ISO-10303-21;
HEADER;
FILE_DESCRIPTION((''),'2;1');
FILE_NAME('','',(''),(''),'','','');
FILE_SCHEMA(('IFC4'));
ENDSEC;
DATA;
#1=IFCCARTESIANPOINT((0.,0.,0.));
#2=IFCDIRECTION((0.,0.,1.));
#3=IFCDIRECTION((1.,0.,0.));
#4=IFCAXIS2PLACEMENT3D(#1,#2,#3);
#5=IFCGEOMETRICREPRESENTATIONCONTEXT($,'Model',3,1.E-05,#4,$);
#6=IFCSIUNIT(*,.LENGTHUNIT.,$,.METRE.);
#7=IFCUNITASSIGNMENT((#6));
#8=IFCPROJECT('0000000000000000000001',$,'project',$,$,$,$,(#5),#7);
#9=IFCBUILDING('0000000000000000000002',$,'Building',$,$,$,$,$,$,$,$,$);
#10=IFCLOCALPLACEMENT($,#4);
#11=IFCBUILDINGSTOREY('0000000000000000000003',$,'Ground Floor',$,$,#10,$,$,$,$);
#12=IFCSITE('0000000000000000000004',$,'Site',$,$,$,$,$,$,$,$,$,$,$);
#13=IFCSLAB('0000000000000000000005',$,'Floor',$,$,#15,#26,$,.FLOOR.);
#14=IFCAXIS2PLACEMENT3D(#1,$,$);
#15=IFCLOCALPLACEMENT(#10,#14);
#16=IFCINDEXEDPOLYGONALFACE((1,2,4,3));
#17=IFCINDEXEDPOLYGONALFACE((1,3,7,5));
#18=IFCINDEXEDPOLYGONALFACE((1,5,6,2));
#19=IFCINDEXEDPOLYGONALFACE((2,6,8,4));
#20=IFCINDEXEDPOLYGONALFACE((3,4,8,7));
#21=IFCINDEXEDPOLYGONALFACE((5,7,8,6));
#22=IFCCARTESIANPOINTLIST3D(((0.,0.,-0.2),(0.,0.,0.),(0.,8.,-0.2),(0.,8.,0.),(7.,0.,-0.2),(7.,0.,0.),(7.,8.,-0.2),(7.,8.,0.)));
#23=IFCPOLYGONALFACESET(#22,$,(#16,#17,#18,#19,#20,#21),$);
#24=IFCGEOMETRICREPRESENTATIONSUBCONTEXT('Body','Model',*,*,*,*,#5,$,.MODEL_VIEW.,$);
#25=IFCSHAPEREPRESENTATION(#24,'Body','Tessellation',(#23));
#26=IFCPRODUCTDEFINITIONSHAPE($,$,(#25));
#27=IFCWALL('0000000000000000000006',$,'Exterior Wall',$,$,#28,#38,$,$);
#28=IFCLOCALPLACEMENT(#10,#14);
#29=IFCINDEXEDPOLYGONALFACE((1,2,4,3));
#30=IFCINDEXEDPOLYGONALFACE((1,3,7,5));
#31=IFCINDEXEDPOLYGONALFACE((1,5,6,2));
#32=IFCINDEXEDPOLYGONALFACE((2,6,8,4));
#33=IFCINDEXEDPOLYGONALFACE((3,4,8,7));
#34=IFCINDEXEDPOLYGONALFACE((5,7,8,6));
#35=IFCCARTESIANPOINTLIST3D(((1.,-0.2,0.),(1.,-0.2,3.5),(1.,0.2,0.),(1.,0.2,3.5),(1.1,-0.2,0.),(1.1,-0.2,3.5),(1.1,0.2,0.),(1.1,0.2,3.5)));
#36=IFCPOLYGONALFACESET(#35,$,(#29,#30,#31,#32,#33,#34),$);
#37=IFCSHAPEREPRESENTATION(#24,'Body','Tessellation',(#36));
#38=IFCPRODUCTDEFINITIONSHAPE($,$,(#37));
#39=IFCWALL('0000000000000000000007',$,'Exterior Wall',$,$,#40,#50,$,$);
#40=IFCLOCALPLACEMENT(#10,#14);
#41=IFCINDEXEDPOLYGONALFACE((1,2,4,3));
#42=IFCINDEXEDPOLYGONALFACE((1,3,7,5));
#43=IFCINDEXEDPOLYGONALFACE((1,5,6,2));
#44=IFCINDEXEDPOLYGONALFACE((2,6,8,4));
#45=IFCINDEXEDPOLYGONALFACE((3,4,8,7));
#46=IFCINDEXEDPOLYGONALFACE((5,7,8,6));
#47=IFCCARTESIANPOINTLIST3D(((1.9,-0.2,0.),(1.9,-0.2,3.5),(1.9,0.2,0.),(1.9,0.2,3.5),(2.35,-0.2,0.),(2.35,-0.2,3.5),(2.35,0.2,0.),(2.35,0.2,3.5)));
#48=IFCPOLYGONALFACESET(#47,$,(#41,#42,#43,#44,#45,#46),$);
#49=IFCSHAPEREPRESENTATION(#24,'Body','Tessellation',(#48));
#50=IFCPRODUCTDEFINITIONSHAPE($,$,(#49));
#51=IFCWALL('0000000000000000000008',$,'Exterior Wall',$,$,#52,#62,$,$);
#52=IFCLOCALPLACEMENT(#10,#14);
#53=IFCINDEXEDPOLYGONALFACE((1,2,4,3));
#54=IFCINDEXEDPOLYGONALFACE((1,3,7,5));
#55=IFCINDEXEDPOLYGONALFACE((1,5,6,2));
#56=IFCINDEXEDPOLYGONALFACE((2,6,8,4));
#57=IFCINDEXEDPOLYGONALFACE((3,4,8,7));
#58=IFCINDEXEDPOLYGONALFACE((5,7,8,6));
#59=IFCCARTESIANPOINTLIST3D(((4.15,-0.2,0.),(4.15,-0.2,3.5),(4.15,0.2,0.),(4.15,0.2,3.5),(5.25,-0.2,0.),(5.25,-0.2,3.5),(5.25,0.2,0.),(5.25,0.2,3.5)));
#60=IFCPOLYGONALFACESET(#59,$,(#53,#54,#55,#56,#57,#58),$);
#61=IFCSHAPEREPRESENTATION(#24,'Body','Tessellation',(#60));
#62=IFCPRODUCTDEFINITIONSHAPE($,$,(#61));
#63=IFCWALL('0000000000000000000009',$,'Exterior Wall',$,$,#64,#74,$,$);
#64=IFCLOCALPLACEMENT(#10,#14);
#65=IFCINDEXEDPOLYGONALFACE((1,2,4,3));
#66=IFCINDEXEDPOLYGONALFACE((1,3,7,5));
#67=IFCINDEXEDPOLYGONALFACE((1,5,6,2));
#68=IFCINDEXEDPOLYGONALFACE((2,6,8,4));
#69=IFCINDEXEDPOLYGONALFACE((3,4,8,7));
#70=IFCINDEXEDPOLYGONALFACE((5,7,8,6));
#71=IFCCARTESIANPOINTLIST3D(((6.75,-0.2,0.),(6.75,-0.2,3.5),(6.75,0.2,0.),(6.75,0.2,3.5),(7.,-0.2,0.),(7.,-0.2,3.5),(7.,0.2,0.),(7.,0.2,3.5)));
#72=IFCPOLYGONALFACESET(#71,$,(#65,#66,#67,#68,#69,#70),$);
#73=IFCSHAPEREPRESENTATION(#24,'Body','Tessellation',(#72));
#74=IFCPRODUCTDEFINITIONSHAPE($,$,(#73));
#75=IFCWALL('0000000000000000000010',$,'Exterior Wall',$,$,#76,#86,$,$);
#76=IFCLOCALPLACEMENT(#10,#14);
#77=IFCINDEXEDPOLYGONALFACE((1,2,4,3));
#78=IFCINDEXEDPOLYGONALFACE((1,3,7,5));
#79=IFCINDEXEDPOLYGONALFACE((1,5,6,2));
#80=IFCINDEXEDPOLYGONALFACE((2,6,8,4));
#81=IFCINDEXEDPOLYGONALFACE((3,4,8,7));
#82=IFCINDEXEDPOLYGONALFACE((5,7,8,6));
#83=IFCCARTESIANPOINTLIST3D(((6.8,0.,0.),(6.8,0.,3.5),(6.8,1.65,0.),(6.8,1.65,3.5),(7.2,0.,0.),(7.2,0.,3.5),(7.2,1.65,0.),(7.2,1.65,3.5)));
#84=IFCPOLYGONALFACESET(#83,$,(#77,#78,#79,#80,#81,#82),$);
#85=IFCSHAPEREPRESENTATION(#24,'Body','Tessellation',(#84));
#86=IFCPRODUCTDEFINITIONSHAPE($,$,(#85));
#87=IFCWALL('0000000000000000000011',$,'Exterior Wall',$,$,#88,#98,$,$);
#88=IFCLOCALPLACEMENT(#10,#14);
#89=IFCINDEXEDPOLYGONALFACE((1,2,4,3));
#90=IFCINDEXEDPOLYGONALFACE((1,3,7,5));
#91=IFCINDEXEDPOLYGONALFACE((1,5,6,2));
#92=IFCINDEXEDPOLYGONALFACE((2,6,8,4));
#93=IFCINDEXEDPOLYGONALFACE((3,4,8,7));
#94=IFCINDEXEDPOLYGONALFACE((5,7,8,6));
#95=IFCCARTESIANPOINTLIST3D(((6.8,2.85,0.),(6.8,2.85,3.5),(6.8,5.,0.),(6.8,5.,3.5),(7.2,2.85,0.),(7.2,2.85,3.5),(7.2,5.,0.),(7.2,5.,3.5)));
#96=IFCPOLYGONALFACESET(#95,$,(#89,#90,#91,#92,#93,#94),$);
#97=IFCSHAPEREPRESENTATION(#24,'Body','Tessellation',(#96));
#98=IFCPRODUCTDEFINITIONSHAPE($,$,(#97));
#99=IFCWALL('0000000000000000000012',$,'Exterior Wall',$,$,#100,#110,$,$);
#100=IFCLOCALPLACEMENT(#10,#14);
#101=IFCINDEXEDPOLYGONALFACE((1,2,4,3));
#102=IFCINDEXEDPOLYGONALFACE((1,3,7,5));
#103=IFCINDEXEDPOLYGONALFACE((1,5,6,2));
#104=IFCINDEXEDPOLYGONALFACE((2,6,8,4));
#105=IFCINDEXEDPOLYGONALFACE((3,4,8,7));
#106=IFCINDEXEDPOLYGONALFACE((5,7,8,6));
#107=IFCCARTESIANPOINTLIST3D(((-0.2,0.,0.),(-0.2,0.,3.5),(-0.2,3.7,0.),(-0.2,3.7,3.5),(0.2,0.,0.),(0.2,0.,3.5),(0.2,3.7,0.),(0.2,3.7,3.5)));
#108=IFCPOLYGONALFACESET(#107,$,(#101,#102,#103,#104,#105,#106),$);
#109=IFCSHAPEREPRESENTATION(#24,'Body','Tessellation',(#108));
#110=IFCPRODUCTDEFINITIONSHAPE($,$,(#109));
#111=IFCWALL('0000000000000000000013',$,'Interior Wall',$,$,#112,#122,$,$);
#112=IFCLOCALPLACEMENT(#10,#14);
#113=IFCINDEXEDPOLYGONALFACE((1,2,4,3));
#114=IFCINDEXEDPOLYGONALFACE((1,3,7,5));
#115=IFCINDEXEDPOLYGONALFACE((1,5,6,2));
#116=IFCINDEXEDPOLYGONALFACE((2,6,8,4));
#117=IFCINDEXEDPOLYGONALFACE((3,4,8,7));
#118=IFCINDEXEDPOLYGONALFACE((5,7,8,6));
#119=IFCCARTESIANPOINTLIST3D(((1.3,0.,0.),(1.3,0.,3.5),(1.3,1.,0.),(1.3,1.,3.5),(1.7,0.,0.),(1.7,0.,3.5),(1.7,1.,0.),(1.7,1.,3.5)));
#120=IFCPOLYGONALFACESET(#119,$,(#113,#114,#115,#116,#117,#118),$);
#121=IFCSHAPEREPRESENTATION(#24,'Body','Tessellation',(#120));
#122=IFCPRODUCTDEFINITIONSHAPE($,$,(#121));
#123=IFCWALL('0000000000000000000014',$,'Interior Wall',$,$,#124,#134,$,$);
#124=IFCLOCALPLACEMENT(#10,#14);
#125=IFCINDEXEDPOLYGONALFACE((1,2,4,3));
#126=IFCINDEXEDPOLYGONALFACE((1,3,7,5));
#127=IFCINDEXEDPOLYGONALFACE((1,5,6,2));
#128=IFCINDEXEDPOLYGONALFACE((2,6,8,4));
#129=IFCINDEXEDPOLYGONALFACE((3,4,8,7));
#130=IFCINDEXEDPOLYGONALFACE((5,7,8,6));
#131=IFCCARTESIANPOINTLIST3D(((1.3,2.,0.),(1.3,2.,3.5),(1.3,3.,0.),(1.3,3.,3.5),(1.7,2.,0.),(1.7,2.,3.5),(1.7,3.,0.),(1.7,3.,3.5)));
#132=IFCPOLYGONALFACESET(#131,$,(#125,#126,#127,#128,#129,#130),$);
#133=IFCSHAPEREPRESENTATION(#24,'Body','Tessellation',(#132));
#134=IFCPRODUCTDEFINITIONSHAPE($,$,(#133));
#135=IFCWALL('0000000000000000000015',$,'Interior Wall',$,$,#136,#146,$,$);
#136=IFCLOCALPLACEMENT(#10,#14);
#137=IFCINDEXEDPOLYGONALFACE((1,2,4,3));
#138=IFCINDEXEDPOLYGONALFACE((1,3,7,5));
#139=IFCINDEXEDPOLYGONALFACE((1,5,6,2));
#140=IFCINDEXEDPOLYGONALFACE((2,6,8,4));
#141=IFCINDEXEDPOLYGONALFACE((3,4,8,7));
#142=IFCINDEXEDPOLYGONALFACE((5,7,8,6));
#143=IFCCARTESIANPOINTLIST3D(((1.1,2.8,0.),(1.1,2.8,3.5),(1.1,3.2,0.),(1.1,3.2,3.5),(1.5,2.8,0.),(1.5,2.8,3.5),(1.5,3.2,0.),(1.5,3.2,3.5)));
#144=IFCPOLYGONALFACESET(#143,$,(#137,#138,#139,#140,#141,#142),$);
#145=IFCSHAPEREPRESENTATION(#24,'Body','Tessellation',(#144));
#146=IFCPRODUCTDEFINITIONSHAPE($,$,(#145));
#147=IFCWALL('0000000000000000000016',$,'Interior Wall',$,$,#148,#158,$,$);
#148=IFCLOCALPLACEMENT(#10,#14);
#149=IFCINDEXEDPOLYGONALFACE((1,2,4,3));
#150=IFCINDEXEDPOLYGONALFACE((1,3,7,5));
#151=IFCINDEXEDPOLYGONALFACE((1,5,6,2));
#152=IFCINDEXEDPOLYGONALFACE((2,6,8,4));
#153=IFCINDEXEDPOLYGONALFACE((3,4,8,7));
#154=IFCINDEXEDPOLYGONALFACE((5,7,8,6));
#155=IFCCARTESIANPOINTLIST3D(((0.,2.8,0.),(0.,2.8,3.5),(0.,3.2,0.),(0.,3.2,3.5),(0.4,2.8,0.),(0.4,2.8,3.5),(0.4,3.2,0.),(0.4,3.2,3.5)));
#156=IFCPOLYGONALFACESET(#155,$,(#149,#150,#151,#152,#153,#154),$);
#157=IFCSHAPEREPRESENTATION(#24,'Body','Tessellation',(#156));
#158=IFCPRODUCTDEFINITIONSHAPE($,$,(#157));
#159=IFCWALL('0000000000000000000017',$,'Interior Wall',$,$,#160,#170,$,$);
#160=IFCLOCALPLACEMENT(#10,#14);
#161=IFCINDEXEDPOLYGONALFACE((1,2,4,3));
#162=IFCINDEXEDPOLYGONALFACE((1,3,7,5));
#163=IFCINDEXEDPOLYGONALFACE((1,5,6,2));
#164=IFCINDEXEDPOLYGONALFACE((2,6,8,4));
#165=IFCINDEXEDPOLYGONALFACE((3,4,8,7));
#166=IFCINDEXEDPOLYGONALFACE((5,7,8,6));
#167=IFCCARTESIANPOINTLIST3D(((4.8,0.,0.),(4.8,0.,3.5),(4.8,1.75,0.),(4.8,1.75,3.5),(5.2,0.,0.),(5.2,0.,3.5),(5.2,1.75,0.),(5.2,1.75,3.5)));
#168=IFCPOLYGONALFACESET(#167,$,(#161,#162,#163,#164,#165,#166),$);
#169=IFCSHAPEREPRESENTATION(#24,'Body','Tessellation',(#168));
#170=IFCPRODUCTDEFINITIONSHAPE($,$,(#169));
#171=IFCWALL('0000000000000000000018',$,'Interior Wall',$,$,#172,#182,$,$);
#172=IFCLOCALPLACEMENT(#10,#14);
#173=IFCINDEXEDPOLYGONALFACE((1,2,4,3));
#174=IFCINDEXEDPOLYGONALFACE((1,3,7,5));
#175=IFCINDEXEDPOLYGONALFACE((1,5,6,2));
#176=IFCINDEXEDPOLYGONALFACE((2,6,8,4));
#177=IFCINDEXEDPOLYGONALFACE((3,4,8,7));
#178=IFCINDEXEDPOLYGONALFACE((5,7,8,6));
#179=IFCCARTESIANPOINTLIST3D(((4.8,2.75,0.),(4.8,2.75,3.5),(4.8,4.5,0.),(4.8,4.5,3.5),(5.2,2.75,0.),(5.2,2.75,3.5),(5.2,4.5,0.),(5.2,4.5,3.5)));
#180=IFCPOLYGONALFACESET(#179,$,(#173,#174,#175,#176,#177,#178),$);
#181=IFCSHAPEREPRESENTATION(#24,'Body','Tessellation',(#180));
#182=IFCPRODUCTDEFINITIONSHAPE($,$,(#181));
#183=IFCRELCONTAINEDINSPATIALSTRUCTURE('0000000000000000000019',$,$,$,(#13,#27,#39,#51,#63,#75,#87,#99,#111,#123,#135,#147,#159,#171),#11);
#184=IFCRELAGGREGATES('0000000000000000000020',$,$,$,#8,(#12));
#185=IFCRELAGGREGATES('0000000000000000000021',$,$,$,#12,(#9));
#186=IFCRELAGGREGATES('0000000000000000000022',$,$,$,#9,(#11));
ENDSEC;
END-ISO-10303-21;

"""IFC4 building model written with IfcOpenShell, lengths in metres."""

from ifc_helpers import new_model, si_unit, frame, origin_with_axes, place, context, subcontext, project, spatial, indexed_curve, outline, extrude, element, save


model = new_model("IFC4")

# Units and contexts
model_context = context("Model", 3, precision=1e-05, world=origin_with_axes())
body_context = subcontext(model_context, "Body", "Model", "MODEL_VIEW")
ifc_project = project(units=[si_unit("LENGTHUNIT", "METRE")], contexts=[model_context])

# Site, building, storey
site = spatial("IfcSite", under=ifc_project, Name="Site")
building = spatial("IfcBuilding", under=site, Name="Building")
storey_placement = place(None, origin_with_axes())
storey = spatial("IfcBuildingStorey", under=building, at=storey_placement, Name="Ground Floor")

# Slab
slab_placement = place(storey_placement, frame((0.0, 0.0, -0.2), z_axis=(0.0, 0.0, 1.0), x_axis=(1.0, 0.0, 0.0)))
element("IfcSlab", 1, at=slab_placement, inside=storey, Name="Floor", PredefinedType="FLOOR", context=body_context, shape_type="SweptSolid", body=[
    extrude(outline(indexed_curve([(0.0, 0.0), (7.0, 0.0), (7.0, 8.0), (0.0, 8.0)])), None, (0.0, 0.0, 1.0), 0.2),
])

# Walls
wall_1_placement = place(storey_placement, frame((1.0, 0.0, 0.0), z_axis=(0.0, 0.0, 1.0), x_axis=(1.0, 0.0, 0.0)))
element("IfcWall", 2, at=wall_1_placement, inside=storey, Name="Exterior Wall", context=body_context, shape_type="SweptSolid", body=[
    extrude(outline(indexed_curve([(0.0, 0.0), (0.0, 0.4), (0.1, 0.4), (0.1, 0.0), (0.0, 0.0)], self_intersect=False)), frame((0.0, -0.2, 0.0), z_axis=(0.0, 0.0, 1.0), x_axis=(1.0, 0.0, 0.0)), (0.0, 0.0, 1.0), 3.5),
])
wall_2_placement = place(storey_placement, frame((1.9, 0.0, 0.0), z_axis=(0.0, 0.0, 1.0), x_axis=(1.0, 0.0, 0.0)))
element("IfcWall", 3, at=wall_2_placement, inside=storey, Name="Exterior Wall", context=body_context, shape_type="SweptSolid", body=[
    extrude(outline(indexed_curve([(0.0, 0.0), (0.0, 0.4), (0.45, 0.4), (0.45, 0.0), (0.0, 0.0)], self_intersect=False)), frame((0.0, -0.2, 0.0), z_axis=(0.0, 0.0, 1.0), x_axis=(1.0, 0.0, 0.0)), (0.0, 0.0, 1.0), 3.5),
])
wall_3_placement = place(storey_placement, frame((4.15, 0.0, 0.0), z_axis=(0.0, 0.0, 1.0), x_axis=(1.0, 0.0, 0.0)))
element("IfcWall", 4, at=wall_3_placement, inside=storey, Name="Exterior Wall", context=body_context, shape_type="SweptSolid", body=[
    extrude(outline(indexed_curve([(0.0, 0.0), (0.0, 0.4), (1.1, 0.4), (1.1, 0.0), (0.0, 0.0)], self_intersect=False)), frame((0.0, -0.2, 0.0), z_axis=(0.0, 0.0, 1.0), x_axis=(1.0, 0.0, 0.0)), (0.0, 0.0, 1.0), 3.5),
])
wall_4_placement = place(storey_placement, frame((6.75, 0.0, 0.0), z_axis=(0.0, 0.0, 1.0), x_axis=(1.0, 0.0, 0.0)))
element("IfcWall", 5, at=wall_4_placement, inside=storey, Name="Exterior Wall", context=body_context, shape_type="SweptSolid", body=[
    extrude(outline(indexed_curve([(0.0, 0.0), (0.0, 0.4), (0.25, 0.4), (0.25, 0.0), (0.0, 0.0)], self_intersect=False)), frame((0.0, -0.2, 0.0), z_axis=(0.0, 0.0, 1.0), x_axis=(1.0, 0.0, 0.0)), (0.0, 0.0, 1.0), 3.5),
])
wall_5_placement = place(storey_placement, frame((7.0, 0.0, 0.0), z_axis=(0.0, 0.0, 1.0), x_axis=(0.0, 1.0, 0.0)))
element("IfcWall", 6, at=wall_5_placement, inside=storey, Name="Exterior Wall", context=body_context, shape_type="SweptSolid", body=[
    extrude(outline(indexed_curve([(0.0, 0.0), (0.0, 0.4), (1.65, 0.4), (1.65, 0.0), (0.0, 0.0)], self_intersect=False)), frame((0.0, -0.2, 0.0), z_axis=(0.0, 0.0, 1.0), x_axis=(1.0, 0.0, 0.0)), (0.0, 0.0, 1.0), 3.5),
])
wall_6_placement = place(storey_placement, frame((7.0, 2.85, 0.0), z_axis=(0.0, 0.0, 1.0), x_axis=(0.0, 1.0, 0.0)))
element("IfcWall", 7, at=wall_6_placement, inside=storey, Name="Exterior Wall", context=body_context, shape_type="SweptSolid", body=[
    extrude(outline(indexed_curve([(0.0, 0.0), (0.0, 0.4), (2.15, 0.4), (2.15, 0.0), (0.0, 0.0)], self_intersect=False)), frame((0.0, -0.2, 0.0), z_axis=(0.0, 0.0, 1.0), x_axis=(1.0, 0.0, 0.0)), (0.0, 0.0, 1.0), 3.5),
])
wall_7_placement = place(storey_placement, frame((0.0, 3.7, 0.0), z_axis=(0.0, 0.0, 1.0), x_axis=(0.0, -1.0, 0.0)))
element("IfcWall", 8, at=wall_7_placement, inside=storey, Name="Exterior Wall", context=body_context, shape_type="SweptSolid", body=[
    extrude(outline(indexed_curve([(0.0, 0.0), (0.0, 0.4), (3.7, 0.4), (3.7, 0.0), (0.0, 0.0)], self_intersect=False)), frame((0.0, -0.2, 0.0), z_axis=(0.0, 0.0, 1.0), x_axis=(1.0, 0.0, 0.0)), (0.0, 0.0, 1.0), 3.5),
])
for number, where, z_axis, x_axis, name in (
    (9, (1.5, 0.0, 0.0), (0.0, 0.0, 1.0), (0.0, 1.0, 0.0), "Interior Wall"),
    (10, (1.5, 2.0, 0.0), (0.0, 0.0, 1.0), (0.0, 1.0, 0.0), "Interior Wall"),
):
    element("IfcWall", number, at=place(storey_placement, frame(where, z_axis=z_axis, x_axis=x_axis)), inside=storey, Name=name, context=body_context, shape_type="SweptSolid", body=[
        extrude(outline(indexed_curve([(0.0, 0.0), (0.0, 0.4), (1.0, 0.4), (1.0, 0.0), (0.0, 0.0)], self_intersect=False)), frame((0.0, -0.2, 0.0), z_axis=(0.0, 0.0, 1.0), x_axis=(1.0, 0.0, 0.0)), (0.0, 0.0, 1.0), 3.5),
    ])
for number, where, z_axis, x_axis, name in (
    (11, (1.5, 3.0, 0.0), (0.0, 0.0, 1.0), (-1.0, 0.0, 0.0), "Interior Wall"),
    (12, (0.4, 3.0, 0.0), (0.0, 0.0, 1.0), (-1.0, 0.0, 0.0), "Interior Wall"),
):
    element("IfcWall", number, at=place(storey_placement, frame(where, z_axis=z_axis, x_axis=x_axis)), inside=storey, Name=name, context=body_context, shape_type="SweptSolid", body=[
        extrude(outline(indexed_curve([(0.0, 0.0), (0.0, 0.4), (0.4, 0.4), (0.4, 0.0), (0.0, 0.0)], self_intersect=False)), frame((0.0, -0.2, 0.0), z_axis=(0.0, 0.0, 1.0), x_axis=(1.0, 0.0, 0.0)), (0.0, 0.0, 1.0), 3.5),
    ])
for number, where, z_axis, x_axis, name in (
    (13, (5.0, 0.0, 0.0), (0.0, 0.0, 1.0), (0.0, 1.0, 0.0), "Interior Wall"),
    (14, (5.0, 2.75, 0.0), (0.0, 0.0, 1.0), (0.0, 1.0, 0.0), "Interior Wall"),
):
    element("IfcWall", number, at=place(storey_placement, frame(where, z_axis=z_axis, x_axis=x_axis)), inside=storey, Name=name, context=body_context, shape_type="SweptSolid", body=[
        extrude(outline(indexed_curve([(0.0, 0.0), (0.0, 0.4), (1.75, 0.4), (1.75, 0.0), (0.0, 0.0)], self_intersect=False)), frame((0.0, -0.2, 0.0), z_axis=(0.0, 0.0, 1.0), x_axis=(1.0, 0.0, 0.0)), (0.0, 0.0, 1.0), 3.5),
    ])

save(model, "model.ifc")
